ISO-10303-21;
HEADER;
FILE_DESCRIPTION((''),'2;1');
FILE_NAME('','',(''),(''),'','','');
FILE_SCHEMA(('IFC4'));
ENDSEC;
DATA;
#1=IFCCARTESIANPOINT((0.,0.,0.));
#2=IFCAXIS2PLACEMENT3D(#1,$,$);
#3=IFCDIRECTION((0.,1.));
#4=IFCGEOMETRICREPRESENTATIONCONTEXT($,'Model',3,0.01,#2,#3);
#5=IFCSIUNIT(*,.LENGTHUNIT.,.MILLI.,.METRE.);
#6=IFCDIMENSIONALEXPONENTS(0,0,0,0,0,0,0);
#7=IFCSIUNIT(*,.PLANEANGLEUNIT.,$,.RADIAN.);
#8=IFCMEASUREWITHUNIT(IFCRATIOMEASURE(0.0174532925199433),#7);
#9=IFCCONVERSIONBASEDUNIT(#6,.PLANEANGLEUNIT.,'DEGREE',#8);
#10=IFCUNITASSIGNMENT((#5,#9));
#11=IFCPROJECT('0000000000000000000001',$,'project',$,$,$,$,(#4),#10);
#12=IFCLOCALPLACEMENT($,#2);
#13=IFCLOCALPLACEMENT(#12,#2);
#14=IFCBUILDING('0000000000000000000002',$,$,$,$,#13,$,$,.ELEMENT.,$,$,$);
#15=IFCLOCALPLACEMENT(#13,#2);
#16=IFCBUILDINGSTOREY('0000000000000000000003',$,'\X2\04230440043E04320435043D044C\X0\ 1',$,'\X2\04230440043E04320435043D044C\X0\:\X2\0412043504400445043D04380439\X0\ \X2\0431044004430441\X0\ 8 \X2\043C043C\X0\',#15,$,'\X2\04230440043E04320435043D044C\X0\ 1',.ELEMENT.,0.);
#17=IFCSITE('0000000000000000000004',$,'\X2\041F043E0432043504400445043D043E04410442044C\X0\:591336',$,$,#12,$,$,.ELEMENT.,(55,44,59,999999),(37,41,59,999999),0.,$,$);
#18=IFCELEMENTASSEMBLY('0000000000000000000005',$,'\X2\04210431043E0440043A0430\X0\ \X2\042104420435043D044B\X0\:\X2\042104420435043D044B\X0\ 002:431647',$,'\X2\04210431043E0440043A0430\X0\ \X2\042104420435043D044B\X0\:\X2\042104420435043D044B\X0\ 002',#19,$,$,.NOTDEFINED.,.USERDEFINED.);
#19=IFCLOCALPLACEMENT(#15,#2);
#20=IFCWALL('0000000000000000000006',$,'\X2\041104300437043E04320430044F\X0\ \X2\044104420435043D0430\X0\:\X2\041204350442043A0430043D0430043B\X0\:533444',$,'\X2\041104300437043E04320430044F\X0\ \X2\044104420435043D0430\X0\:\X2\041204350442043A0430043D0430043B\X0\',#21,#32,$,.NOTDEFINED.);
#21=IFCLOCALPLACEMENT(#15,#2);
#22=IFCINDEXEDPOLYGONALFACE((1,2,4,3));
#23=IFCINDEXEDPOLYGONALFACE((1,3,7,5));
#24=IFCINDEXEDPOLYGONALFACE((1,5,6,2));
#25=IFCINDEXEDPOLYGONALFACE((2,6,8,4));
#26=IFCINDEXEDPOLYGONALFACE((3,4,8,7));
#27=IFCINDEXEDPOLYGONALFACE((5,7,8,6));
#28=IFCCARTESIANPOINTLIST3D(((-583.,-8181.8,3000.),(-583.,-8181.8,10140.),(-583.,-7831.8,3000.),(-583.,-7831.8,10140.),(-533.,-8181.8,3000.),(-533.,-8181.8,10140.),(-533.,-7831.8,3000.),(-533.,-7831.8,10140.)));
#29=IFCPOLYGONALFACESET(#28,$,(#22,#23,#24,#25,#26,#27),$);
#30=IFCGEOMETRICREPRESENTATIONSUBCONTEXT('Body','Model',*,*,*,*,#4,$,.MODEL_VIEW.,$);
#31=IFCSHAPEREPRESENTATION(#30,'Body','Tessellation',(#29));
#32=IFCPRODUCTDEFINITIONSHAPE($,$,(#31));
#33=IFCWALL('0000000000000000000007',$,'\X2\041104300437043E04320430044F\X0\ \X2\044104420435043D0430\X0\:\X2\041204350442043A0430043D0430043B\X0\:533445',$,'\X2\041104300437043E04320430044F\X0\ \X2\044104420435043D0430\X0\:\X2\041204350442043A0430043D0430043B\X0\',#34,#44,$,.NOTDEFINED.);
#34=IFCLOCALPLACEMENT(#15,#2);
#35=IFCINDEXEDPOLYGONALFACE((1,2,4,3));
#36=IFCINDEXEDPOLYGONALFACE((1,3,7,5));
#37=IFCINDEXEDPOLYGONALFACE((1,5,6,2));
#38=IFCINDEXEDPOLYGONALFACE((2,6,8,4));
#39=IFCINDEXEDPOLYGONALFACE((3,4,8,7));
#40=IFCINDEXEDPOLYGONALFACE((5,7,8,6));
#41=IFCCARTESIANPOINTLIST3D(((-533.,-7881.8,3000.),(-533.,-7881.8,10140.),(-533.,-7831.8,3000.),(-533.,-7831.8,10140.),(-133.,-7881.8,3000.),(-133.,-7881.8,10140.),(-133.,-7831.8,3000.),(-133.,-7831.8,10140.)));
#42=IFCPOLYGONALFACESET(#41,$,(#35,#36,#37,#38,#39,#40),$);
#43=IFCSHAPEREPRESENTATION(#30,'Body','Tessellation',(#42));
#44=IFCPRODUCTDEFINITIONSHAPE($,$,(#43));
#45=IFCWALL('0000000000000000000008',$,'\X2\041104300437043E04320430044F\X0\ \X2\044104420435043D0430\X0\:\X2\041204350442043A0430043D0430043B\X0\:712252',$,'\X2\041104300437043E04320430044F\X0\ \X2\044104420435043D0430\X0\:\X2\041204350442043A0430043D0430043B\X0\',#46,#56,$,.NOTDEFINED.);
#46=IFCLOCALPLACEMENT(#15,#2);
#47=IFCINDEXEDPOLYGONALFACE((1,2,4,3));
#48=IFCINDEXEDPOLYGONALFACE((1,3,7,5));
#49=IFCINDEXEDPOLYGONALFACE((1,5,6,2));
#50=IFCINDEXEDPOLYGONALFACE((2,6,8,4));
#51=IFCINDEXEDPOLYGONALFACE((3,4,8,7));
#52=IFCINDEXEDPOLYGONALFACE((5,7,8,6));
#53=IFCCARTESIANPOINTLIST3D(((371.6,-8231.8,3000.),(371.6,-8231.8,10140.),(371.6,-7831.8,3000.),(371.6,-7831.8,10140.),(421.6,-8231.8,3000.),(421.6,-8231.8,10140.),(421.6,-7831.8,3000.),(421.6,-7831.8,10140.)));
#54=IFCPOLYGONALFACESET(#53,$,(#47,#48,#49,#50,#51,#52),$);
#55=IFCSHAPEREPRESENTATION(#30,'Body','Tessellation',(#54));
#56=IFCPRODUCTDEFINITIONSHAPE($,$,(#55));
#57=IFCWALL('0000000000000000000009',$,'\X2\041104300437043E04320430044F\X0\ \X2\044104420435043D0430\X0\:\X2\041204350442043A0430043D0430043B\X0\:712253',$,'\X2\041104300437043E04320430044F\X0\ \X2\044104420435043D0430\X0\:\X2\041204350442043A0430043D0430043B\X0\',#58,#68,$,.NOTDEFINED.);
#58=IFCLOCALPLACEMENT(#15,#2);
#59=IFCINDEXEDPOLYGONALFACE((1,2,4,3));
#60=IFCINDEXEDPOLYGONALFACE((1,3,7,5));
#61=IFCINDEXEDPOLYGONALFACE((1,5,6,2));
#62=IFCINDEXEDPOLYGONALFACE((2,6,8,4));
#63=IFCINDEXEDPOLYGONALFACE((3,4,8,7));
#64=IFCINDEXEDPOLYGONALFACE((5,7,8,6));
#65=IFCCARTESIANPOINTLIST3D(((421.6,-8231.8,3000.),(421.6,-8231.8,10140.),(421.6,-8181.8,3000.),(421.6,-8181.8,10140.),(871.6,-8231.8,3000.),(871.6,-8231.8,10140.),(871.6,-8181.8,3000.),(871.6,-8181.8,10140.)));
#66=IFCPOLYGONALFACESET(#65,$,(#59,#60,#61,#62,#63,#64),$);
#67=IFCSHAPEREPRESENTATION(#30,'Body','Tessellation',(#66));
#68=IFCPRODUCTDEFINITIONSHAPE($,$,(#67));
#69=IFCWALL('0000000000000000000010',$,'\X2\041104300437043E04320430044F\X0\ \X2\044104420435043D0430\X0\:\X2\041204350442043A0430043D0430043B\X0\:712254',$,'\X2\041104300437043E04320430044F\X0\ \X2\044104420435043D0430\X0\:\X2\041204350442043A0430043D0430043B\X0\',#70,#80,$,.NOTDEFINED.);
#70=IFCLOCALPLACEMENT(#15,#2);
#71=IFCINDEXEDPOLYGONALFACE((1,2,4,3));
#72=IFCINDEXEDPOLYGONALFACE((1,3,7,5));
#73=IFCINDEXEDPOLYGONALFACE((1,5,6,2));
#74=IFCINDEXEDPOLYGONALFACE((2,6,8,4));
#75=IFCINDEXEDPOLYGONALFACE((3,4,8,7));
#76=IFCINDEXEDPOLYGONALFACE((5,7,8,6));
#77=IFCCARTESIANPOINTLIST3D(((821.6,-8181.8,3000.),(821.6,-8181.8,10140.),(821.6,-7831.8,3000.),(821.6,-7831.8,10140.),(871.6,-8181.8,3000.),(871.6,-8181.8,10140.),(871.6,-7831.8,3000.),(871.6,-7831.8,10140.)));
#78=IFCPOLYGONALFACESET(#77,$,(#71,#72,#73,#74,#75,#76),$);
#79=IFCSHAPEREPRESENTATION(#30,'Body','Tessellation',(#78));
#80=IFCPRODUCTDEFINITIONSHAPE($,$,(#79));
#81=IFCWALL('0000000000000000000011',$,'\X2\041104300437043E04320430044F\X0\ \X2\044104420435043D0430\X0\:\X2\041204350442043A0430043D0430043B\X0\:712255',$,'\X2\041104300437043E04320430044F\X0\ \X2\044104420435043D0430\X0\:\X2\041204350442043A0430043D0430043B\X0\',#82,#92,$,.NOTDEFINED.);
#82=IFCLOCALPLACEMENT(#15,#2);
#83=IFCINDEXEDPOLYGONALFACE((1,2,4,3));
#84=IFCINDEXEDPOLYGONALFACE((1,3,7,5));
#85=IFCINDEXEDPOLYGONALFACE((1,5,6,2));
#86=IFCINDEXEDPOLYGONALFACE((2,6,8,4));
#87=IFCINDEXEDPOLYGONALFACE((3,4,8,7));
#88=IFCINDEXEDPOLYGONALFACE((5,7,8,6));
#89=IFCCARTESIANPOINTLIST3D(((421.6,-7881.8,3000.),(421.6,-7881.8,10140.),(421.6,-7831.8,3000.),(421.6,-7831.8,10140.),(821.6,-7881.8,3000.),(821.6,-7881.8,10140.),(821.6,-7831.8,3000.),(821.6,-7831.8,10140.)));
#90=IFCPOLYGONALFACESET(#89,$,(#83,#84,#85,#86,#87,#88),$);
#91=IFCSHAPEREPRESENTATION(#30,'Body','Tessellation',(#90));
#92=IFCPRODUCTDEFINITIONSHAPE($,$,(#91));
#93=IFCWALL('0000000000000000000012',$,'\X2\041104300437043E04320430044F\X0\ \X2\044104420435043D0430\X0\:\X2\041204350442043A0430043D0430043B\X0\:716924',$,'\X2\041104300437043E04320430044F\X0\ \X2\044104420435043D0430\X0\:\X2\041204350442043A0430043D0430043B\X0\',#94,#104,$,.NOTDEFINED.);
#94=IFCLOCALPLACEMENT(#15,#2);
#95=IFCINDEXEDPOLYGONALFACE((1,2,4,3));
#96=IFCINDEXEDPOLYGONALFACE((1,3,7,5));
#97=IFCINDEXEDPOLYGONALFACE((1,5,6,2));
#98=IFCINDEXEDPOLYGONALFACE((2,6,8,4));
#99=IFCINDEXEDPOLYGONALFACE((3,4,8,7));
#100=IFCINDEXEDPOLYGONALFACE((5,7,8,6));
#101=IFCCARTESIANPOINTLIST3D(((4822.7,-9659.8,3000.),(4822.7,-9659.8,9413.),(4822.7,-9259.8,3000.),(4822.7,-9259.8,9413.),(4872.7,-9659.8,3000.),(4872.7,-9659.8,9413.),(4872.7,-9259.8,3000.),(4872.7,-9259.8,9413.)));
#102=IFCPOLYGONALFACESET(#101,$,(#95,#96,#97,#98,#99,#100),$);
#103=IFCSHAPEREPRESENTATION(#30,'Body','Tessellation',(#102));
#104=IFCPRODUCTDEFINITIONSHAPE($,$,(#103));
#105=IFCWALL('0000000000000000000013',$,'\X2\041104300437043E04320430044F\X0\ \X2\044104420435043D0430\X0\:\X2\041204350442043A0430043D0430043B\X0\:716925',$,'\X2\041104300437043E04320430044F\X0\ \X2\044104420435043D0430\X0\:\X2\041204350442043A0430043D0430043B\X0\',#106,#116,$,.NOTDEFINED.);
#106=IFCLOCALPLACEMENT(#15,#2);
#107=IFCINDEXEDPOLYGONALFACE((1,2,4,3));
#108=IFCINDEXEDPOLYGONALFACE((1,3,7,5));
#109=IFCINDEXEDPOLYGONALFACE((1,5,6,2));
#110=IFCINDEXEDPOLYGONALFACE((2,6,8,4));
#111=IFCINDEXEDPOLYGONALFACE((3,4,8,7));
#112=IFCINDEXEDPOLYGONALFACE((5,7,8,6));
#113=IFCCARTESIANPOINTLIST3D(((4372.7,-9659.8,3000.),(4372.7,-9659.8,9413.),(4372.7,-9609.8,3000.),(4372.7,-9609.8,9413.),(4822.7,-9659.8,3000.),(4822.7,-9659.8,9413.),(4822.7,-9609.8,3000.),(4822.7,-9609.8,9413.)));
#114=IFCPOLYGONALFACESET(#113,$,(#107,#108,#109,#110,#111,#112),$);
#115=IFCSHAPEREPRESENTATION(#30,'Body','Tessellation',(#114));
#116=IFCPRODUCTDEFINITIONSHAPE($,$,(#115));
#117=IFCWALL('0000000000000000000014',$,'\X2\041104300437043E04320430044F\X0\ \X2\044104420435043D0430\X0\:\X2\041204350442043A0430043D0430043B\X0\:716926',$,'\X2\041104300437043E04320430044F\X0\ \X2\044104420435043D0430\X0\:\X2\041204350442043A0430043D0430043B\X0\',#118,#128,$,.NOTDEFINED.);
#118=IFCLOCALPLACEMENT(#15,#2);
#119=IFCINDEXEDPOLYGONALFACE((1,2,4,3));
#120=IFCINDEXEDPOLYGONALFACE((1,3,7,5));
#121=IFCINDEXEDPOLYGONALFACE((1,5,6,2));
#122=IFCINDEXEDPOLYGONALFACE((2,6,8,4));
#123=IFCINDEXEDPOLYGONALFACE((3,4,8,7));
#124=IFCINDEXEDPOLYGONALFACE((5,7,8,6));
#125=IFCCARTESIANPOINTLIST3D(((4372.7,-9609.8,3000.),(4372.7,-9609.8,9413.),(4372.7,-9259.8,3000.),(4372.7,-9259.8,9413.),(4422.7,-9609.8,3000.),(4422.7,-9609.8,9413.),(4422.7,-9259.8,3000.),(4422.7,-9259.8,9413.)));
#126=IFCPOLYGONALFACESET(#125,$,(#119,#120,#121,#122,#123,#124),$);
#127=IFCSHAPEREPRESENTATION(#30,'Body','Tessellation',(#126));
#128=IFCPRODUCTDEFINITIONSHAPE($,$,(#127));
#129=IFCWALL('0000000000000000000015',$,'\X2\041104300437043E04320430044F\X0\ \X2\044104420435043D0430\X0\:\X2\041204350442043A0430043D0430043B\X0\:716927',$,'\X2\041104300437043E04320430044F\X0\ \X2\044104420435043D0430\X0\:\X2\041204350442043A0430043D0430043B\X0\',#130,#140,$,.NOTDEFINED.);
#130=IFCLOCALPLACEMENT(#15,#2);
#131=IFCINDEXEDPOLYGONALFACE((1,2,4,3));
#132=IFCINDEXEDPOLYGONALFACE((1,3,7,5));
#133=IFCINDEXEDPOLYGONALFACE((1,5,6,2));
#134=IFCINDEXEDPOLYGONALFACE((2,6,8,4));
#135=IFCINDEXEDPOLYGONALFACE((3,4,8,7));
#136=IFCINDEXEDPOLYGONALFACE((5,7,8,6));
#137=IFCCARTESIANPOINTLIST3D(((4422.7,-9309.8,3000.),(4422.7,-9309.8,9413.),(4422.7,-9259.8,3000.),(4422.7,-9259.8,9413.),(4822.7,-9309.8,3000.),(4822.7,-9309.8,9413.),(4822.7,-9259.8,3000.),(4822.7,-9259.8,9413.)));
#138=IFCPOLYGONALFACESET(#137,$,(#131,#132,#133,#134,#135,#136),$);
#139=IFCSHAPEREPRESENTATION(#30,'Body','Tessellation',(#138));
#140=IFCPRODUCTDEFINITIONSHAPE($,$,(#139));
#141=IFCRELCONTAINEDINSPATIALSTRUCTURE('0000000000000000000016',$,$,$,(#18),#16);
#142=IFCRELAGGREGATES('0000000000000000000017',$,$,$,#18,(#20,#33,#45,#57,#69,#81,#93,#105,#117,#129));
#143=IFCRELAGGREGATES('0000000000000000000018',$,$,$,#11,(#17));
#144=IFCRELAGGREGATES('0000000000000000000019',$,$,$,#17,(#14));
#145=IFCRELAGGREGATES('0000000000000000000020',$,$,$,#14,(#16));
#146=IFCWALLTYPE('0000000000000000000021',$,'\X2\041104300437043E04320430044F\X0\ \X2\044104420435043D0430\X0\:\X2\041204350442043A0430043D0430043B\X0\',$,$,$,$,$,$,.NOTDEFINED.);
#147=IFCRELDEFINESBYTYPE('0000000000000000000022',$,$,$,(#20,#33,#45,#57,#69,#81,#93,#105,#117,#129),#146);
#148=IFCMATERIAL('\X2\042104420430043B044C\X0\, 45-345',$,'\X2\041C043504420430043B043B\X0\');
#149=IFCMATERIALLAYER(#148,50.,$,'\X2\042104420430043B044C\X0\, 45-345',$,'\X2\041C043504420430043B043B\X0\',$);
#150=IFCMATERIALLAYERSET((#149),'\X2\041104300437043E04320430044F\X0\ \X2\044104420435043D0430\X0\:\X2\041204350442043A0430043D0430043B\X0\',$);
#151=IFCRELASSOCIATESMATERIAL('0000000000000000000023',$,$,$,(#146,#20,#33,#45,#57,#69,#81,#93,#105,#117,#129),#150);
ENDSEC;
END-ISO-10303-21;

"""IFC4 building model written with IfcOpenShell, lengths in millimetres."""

from ifc_helpers import new_model, entity, si_unit, converted_unit, direction, frame, origin, place, context, subcontext, project, spatial, indexed_curve, outline, extrude, material, layer, layer_set, type_object, element, aggregate, save


model = new_model("IFC4")

# Units and contexts
model_context = context("Model", 3, precision=0.01, world=origin(), true_north=direction((0.0, 1.0)))
body_context = subcontext(model_context, "Body", "Model", "MODEL_VIEW")
ifc_project = project(units=[si_unit("LENGTHUNIT", "METRE", prefix="MILLI"), converted_unit("PLANEANGLEUNIT", "DEGREE", entity("IfcRatioMeasure", 0.0174532925199433), si_unit("PLANEANGLEUNIT", "RADIAN"), dimensions=[0, 0, 0, 0, 0, 0, 0])], contexts=[model_context])

# Site, building, storey
site_placement = place(None, origin())
site = spatial("IfcSite", under=ifc_project, at=site_placement, Name="Поверхность:591336", CompositionType="ELEMENT", RefLatitude=(55, 44, 59, 999999), RefLongitude=(37, 41, 59, 999999), RefElevation=0.0)
building_placement = place(site_placement, origin())
building = spatial("IfcBuilding", under=site, at=building_placement, CompositionType="ELEMENT")
storey_placement = place(building_placement, origin())
storey = spatial("IfcBuildingStorey", under=building, at=storey_placement, Name="Уровень 1", ObjectType="Уровень:Верхний брус 8 мм", LongName="Уровень 1", CompositionType="ELEMENT", Elevation=0.0)

# Element assembly, walls
assembly_placement = place(storey_placement, origin())
assembly = element("IfcElementAssembly", 1, at=assembly_placement, inside=storey, Name="Сборка Стены:Стены 002:431647", ObjectType="Сборка Стены:Стены 002", AssemblyPlace="NOTDEFINED", PredefinedType="USERDEFINED")
ifc_material_1 = material(Name="Сталь, 45-345", Category="Металл")
ifc_layer_1 = layer(ifc_material_1, 50.0, Name="Сталь, 45-345", Category="Металл")
ifc_layer_set_1 = layer_set([ifc_layer_1], Name="Базовая стена:Ветканал")
wall_type_1 = type_object("IfcWallType", Name="Базовая стена:Ветканал", PredefinedType="NOTDEFINED", material=ifc_layer_set_1)
wall_1_placement = place(assembly_placement, frame((-558.0, -8181.8, 3000.0), z_axis=(0.0, 0.0, 1.0), x_axis=(0.0, 1.0, 0.0)))
wall_1 = element("IfcWall", 2, at=wall_1_placement, type_object=wall_type_1, material=ifc_layer_set_1, Name="Базовая стена:Ветканал:533444", ObjectType="Базовая стена:Ветканал", PredefinedType="NOTDEFINED", context=body_context, shape_type="SweptSolid", body=[
    extrude(outline(indexed_curve([(350.0, 25.0), (0.0, 25.0), (0.0, -25.0), (350.0, -25.0), (350.0, 25.0)], self_intersect=False)), origin(), (0.0, 0.0, 1.0), 7140.0),
])
wall_2_placement = place(assembly_placement, frame((-533.0, -7856.8, 3000.0)))
wall_2 = element("IfcWall", 3, at=wall_2_placement, type_object=wall_type_1, material=ifc_layer_set_1, Name="Базовая стена:Ветканал:533445", ObjectType="Базовая стена:Ветканал", PredefinedType="NOTDEFINED", context=body_context, shape_type="SweptSolid", body=[
    extrude(outline(indexed_curve([(400.0, 25.0), (0.0, 25.0), (0.0, -25.0), (400.0, -25.0), (400.0, 25.0)], self_intersect=False)), origin(), (0.0, 0.0, 1.0), 7140.0),
])
wall_3_placement = place(assembly_placement, frame((396.6, -7831.8, 3000.0), z_axis=(0.0, 0.0, 1.0), x_axis=(0.0, -1.0, 0.0)))
wall_3 = element("IfcWall", 4, at=wall_3_placement, type_object=wall_type_1, material=ifc_layer_set_1, Name="Базовая стена:Ветканал:712252", ObjectType="Базовая стена:Ветканал", PredefinedType="NOTDEFINED", context=body_context, shape_type="SweptSolid", body=[
    extrude(outline(indexed_curve([(400.0, 25.0), (0.0, 25.0), (0.0, -25.0), (400.0, -25.0), (400.0, 25.0)], self_intersect=False)), origin(), (0.0, 0.0, 1.0), 7140.0),
])
wall_4_placement = place(assembly_placement, frame((421.6, -8206.8, 3000.0)))
wall_4 = element("IfcWall", 5, at=wall_4_placement, type_object=wall_type_1, material=ifc_layer_set_1, Name="Базовая стена:Ветканал:712253", ObjectType="Базовая стена:Ветканал", PredefinedType="NOTDEFINED", context=body_context, shape_type="SweptSolid", body=[
    extrude(outline(indexed_curve([(450.0, 25.0), (0.0, 25.0), (0.0, -25.0), (450.0, -25.0), (450.0, 25.0)], self_intersect=False)), origin(), (0.0, 0.0, 1.0), 7140.0),
])
wall_5_placement = place(assembly_placement, frame((846.6, -8181.8, 3000.0), z_axis=(0.0, 0.0, 1.0), x_axis=(0.0, 1.0, 0.0)))
wall_5 = element("IfcWall", 6, at=wall_5_placement, type_object=wall_type_1, material=ifc_layer_set_1, Name="Базовая стена:Ветканал:712254", ObjectType="Базовая стена:Ветканал", PredefinedType="NOTDEFINED", context=body_context, shape_type="SweptSolid", body=[
    extrude(outline(indexed_curve([(350.0, 25.0), (0.0, 25.0), (0.0, -25.0), (350.0, -25.0), (350.0, 25.0)], self_intersect=False)), origin(), (0.0, 0.0, 1.0), 7140.0),
])
wall_6_placement = place(assembly_placement, frame((821.6, -7856.8, 3000.0), z_axis=(0.0, 0.0, 1.0), x_axis=(-1.0, 0.0, 0.0)))
wall_6 = element("IfcWall", 7, at=wall_6_placement, type_object=wall_type_1, material=ifc_layer_set_1, Name="Базовая стена:Ветканал:712255", ObjectType="Базовая стена:Ветканал", PredefinedType="NOTDEFINED", context=body_context, shape_type="SweptSolid", body=[
    extrude(outline(indexed_curve([(400.0, 25.0), (0.0, 25.0), (0.0, -25.0), (400.0, -25.0), (400.0, 25.0)], self_intersect=False)), origin(), (0.0, 0.0, 1.0), 7140.0),
])
wall_7_placement = place(assembly_placement, frame((4847.7, -9259.8, 3000.0), z_axis=(0.0, 0.0, 1.0), x_axis=(0.0, -1.0, 0.0)))
wall_7 = element("IfcWall", 8, at=wall_7_placement, type_object=wall_type_1, material=ifc_layer_set_1, Name="Базовая стена:Ветканал:716924", ObjectType="Базовая стена:Ветканал", PredefinedType="NOTDEFINED", context=body_context, shape_type="SweptSolid", body=[
    extrude(outline(indexed_curve([(400.0, 25.0), (0.0, 25.0), (0.0, -25.0), (400.0, -25.0), (400.0, 25.0)], self_intersect=False)), origin(), (0.0, 0.0, 1.0), 6413.0),
])
wall_8_placement = place(assembly_placement, frame((4822.7, -9634.8, 3000.0), z_axis=(0.0, 0.0, 1.0), x_axis=(-1.0, 0.0, 0.0)))
wall_8 = element("IfcWall", 9, at=wall_8_placement, type_object=wall_type_1, material=ifc_layer_set_1, Name="Базовая стена:Ветканал:716925", ObjectType="Базовая стена:Ветканал", PredefinedType="NOTDEFINED", context=body_context, shape_type="SweptSolid", body=[
    extrude(outline(indexed_curve([(450.0, 25.0), (0.0, 25.0), (0.0, -25.0), (450.0, -25.0), (450.0, 25.0)], self_intersect=False)), origin(), (0.0, 0.0, 1.0), 6413.0),
])
wall_9_placement = place(assembly_placement, frame((4397.7, -9609.8, 3000.0), z_axis=(0.0, 0.0, 1.0), x_axis=(0.0, 1.0, 0.0)))
wall_9 = element("IfcWall", 10, at=wall_9_placement, type_object=wall_type_1, material=ifc_layer_set_1, Name="Базовая стена:Ветканал:716926", ObjectType="Базовая стена:Ветканал", PredefinedType="NOTDEFINED", context=body_context, shape_type="SweptSolid", body=[
    extrude(outline(indexed_curve([(350.0, 25.0), (0.0, 25.0), (0.0, -25.0), (350.0, -25.0), (350.0, 25.0)], self_intersect=False)), origin(), (0.0, 0.0, 1.0), 6413.0),
])
wall_10_placement = place(assembly_placement, frame((4422.7, -9284.8, 3000.0)))
wall_10 = element("IfcWall", 11, at=wall_10_placement, type_object=wall_type_1, material=ifc_layer_set_1, Name="Базовая стена:Ветканал:716927", ObjectType="Базовая стена:Ветканал", PredefinedType="NOTDEFINED", context=body_context, shape_type="SweptSolid", body=[
    extrude(outline(indexed_curve([(400.0, 25.0), (0.0, 25.0), (0.0, -25.0), (400.0, -25.0), (400.0, 25.0)], self_intersect=False)), origin(), (0.0, 0.0, 1.0), 6413.0),
])
aggregate(assembly, [wall_1, wall_2, wall_3, wall_4, wall_5, wall_6, wall_7, wall_8, wall_9, wall_10])

save(model, "model.ifc")
